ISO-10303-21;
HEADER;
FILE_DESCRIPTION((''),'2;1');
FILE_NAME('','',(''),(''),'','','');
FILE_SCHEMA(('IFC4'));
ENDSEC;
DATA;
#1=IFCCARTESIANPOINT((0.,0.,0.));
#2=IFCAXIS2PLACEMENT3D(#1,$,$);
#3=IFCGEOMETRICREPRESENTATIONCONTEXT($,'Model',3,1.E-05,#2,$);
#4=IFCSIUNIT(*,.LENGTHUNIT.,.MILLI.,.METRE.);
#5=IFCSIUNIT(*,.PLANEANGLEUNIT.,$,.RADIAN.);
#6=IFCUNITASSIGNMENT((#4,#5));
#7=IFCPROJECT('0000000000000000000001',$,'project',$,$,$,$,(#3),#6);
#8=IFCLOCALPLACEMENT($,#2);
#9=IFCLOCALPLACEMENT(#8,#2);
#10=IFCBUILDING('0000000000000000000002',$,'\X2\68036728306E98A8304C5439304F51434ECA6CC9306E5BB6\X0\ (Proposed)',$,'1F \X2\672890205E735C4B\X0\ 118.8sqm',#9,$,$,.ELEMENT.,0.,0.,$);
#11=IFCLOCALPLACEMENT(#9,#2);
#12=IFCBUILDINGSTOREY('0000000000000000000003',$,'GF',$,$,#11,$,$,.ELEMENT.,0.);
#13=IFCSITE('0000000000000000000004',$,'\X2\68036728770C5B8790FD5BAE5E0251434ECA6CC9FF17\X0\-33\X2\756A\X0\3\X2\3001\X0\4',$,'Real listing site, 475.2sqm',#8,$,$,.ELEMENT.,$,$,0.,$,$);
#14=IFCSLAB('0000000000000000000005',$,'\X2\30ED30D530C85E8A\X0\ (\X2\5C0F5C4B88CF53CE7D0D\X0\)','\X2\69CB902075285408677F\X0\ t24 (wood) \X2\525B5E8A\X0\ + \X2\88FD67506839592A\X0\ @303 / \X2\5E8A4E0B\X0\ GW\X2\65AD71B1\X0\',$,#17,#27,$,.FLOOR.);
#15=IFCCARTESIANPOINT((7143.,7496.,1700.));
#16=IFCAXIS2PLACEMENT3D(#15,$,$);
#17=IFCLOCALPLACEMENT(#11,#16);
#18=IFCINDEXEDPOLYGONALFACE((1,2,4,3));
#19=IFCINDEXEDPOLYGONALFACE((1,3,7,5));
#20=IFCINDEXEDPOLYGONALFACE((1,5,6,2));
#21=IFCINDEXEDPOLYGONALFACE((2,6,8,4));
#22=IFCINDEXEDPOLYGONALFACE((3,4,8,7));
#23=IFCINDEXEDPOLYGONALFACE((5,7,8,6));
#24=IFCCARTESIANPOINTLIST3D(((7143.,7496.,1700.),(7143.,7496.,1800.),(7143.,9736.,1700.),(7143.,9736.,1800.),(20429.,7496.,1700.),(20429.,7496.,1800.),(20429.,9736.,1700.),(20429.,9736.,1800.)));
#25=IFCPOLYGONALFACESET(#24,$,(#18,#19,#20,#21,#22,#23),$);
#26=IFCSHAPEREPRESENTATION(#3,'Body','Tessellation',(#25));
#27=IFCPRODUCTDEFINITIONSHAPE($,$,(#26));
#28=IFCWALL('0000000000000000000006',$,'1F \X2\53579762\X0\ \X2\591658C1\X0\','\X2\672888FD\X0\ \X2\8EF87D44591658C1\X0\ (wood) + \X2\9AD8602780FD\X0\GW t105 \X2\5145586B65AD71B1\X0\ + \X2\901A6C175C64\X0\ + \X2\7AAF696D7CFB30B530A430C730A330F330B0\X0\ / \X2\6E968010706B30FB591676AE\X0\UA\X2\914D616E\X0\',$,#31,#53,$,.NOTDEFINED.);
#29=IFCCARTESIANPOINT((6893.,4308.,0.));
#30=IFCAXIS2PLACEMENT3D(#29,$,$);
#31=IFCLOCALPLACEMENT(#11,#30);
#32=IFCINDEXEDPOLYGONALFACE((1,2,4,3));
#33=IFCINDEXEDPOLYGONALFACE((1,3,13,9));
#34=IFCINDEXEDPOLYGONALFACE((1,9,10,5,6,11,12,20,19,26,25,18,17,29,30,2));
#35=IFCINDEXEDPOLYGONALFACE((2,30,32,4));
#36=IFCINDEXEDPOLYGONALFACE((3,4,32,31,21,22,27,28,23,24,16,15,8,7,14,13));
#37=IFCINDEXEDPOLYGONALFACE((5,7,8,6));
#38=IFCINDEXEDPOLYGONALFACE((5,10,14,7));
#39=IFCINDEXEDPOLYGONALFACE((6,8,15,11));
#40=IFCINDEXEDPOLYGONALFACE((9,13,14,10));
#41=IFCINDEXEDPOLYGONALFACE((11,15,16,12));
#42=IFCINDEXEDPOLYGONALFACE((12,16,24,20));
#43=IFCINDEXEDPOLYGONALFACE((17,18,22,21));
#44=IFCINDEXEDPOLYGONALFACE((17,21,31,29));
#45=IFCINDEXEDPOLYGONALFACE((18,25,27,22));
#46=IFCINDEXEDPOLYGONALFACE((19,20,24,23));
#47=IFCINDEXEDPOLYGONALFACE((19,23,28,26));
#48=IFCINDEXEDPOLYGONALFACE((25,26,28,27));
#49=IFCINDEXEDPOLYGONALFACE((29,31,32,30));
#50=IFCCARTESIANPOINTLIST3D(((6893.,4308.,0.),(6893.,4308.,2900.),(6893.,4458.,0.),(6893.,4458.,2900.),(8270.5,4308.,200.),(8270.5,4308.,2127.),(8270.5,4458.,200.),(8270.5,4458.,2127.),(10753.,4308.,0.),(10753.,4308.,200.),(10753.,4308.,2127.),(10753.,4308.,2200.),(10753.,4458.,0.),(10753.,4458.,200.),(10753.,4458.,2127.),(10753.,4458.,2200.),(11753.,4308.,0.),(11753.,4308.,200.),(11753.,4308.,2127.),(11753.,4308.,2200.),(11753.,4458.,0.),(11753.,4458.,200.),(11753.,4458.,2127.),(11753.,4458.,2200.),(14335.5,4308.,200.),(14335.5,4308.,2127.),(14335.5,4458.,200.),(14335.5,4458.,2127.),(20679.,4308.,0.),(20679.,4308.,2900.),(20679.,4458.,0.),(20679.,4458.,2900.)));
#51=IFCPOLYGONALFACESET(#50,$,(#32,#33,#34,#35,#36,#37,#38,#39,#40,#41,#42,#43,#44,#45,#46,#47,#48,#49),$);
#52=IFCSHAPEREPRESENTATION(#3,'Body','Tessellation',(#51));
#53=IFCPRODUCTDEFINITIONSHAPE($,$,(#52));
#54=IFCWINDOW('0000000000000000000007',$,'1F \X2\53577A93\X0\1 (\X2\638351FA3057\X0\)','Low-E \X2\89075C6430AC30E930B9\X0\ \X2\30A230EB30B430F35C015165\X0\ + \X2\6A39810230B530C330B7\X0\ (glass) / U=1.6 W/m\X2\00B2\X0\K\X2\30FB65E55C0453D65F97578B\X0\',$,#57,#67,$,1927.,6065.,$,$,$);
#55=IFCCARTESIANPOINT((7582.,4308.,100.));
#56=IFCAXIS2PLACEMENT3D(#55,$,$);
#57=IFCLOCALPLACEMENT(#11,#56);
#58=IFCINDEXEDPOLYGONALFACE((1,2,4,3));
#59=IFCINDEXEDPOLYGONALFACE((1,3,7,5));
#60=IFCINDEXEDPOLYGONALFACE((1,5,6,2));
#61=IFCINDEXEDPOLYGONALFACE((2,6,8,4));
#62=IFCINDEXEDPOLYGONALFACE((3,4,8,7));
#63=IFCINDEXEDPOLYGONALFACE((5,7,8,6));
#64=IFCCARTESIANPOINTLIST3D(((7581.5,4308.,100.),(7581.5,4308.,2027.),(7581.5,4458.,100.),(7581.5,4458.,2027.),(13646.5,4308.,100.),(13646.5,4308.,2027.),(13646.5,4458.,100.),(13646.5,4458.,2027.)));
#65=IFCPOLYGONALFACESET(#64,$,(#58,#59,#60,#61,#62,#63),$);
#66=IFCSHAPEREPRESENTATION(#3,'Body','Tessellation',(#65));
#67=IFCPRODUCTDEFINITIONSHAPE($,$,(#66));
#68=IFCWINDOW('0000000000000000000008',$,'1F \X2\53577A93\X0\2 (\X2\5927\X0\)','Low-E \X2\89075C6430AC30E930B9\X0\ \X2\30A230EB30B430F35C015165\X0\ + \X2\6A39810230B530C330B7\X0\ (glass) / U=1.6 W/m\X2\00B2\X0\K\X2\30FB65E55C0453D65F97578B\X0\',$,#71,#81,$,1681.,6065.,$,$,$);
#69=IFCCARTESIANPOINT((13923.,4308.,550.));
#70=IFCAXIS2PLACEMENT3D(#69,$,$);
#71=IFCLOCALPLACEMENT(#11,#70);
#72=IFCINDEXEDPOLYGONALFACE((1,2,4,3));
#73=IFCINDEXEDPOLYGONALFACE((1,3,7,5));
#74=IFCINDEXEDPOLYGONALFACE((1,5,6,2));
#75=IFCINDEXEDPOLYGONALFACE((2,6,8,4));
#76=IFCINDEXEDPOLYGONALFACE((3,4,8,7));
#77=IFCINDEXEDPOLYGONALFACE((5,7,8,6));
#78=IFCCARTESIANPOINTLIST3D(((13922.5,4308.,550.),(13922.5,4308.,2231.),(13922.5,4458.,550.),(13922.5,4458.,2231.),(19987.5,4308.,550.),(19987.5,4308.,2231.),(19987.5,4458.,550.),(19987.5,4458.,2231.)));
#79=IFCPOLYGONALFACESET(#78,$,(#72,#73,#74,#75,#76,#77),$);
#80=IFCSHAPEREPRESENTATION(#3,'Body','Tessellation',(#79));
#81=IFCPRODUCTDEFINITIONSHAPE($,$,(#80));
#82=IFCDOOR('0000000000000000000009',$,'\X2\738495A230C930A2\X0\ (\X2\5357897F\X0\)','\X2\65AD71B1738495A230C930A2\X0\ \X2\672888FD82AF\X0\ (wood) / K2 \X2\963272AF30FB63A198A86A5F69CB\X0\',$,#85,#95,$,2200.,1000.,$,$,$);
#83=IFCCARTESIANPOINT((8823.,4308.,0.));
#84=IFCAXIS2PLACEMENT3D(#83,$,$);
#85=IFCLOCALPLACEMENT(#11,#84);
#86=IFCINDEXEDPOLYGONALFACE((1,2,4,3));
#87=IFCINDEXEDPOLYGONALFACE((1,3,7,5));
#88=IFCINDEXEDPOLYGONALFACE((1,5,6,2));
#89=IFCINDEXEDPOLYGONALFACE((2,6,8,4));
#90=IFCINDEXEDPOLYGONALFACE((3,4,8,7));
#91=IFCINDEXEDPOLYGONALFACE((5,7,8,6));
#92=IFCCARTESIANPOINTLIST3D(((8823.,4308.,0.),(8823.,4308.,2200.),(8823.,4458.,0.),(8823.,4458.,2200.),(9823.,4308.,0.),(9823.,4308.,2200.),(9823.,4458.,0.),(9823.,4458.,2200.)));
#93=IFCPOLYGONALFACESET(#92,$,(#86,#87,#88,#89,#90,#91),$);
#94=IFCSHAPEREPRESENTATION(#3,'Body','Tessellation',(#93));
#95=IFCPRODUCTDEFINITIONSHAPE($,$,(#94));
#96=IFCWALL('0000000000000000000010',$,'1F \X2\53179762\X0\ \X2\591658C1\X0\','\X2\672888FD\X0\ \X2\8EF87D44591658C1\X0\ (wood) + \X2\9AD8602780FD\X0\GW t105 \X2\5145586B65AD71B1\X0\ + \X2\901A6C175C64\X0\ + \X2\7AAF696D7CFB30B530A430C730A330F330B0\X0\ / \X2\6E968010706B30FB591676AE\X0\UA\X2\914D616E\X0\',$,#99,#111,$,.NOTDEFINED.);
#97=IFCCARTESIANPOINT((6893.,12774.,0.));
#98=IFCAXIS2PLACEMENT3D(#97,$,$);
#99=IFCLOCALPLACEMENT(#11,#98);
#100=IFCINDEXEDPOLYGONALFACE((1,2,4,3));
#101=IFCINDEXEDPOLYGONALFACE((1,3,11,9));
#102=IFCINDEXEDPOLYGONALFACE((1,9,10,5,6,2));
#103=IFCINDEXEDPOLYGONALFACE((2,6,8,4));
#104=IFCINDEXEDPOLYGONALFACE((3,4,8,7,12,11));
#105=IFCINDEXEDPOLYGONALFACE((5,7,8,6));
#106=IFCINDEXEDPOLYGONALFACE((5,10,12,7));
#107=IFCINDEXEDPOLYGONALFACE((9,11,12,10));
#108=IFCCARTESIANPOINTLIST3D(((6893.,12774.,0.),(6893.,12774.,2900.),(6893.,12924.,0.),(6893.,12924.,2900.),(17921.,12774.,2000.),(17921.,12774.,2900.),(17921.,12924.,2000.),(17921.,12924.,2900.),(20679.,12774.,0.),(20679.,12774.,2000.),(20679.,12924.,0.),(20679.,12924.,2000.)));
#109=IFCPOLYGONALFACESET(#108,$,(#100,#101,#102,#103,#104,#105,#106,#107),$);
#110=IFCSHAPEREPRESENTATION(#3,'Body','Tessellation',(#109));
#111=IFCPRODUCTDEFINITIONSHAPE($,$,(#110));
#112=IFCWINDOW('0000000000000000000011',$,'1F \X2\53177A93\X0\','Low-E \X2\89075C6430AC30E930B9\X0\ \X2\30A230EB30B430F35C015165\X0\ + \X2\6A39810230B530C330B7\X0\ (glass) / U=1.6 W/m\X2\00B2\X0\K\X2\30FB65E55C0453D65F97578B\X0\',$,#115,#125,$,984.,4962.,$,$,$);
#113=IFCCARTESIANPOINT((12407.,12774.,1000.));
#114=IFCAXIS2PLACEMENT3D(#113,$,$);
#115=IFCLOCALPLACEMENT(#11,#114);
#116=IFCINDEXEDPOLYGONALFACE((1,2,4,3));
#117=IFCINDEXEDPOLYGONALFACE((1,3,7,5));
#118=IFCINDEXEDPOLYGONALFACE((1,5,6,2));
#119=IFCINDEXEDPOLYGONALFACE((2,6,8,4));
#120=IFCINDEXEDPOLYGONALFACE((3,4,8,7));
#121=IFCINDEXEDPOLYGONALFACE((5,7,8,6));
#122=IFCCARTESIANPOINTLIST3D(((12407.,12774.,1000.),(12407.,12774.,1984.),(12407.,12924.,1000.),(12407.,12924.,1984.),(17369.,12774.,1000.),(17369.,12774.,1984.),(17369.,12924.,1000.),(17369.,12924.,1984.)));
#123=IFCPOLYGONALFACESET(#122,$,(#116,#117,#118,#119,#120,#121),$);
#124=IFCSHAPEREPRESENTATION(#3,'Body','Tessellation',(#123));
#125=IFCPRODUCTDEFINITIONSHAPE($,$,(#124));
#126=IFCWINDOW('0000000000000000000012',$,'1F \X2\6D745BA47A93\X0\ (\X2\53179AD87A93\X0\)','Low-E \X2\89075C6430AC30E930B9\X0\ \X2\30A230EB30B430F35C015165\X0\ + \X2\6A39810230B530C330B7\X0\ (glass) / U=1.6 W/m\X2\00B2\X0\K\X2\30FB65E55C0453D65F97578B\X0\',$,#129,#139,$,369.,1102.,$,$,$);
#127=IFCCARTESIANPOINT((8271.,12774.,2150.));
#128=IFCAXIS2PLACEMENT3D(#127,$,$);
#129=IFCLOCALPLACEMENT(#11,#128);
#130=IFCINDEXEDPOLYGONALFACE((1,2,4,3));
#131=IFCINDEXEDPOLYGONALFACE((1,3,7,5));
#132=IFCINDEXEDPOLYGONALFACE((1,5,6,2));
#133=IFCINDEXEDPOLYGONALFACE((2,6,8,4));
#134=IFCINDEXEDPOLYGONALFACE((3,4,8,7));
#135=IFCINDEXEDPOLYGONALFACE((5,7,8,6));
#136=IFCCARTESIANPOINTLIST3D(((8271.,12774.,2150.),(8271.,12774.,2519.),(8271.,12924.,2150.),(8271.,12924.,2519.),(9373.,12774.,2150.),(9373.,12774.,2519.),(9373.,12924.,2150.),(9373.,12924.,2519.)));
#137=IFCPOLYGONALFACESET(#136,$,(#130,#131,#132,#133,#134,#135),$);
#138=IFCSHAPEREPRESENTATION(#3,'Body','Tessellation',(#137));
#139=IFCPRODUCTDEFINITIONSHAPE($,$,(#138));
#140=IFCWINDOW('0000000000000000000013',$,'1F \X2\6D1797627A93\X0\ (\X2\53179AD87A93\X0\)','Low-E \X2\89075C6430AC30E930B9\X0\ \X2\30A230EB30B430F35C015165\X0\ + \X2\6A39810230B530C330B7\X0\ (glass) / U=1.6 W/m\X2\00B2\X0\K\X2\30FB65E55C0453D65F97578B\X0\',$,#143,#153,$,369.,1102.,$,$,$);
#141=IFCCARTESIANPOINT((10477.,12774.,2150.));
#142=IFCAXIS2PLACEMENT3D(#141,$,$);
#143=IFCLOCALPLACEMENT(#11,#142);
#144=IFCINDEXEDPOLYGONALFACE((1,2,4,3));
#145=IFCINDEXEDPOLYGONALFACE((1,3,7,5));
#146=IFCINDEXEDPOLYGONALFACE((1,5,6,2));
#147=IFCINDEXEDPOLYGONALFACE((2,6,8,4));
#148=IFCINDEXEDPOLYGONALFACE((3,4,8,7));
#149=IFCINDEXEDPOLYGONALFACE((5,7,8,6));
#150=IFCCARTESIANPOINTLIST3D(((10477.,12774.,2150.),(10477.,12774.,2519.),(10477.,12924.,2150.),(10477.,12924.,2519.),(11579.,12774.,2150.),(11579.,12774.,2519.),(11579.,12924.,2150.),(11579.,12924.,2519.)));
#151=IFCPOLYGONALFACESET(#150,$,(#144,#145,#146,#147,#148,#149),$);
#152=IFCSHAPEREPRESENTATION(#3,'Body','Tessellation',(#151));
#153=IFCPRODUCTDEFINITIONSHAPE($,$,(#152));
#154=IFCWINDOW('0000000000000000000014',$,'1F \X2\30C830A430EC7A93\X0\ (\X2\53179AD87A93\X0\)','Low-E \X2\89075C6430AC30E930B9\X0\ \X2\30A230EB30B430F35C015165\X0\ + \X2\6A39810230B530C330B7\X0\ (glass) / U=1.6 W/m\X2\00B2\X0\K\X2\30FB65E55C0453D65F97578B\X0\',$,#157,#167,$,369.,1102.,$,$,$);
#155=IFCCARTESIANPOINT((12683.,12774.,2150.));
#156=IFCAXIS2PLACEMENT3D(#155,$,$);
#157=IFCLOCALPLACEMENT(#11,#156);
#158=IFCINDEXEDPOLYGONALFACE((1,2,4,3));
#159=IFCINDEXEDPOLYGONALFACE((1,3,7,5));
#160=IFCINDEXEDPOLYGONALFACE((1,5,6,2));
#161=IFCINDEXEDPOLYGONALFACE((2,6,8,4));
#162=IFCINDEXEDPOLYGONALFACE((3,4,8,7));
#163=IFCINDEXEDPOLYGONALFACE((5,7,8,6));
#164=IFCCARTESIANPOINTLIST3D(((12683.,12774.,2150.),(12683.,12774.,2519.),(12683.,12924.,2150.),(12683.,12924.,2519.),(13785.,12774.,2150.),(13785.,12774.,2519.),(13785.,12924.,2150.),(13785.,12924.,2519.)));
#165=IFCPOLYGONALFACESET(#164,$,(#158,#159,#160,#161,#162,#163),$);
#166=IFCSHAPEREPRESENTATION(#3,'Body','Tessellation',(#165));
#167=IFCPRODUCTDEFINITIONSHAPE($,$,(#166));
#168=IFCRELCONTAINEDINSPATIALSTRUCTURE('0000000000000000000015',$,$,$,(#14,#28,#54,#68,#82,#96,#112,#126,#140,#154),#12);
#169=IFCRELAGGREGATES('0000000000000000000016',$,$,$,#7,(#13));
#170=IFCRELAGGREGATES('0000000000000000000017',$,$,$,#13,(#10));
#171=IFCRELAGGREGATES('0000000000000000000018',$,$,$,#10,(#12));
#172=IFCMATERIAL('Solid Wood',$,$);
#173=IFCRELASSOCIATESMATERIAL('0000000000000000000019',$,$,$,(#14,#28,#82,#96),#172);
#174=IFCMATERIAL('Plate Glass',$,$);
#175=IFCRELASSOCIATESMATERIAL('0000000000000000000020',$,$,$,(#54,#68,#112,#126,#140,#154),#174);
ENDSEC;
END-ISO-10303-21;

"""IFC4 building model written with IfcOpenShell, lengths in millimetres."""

from ifc_helpers import new_model, si_unit, frame, frame_2d, origin, place, context, project, spatial, rectangle, extrude, material, element, fill, save


model = new_model("IFC4")

# Units and contexts
model_context = context("Model", 3, precision=1e-05, world=origin())
ifc_project = project(units=[si_unit("LENGTHUNIT", "METRE", prefix="MILLI"), si_unit("PLANEANGLEUNIT", "RADIAN")], contexts=[model_context])

# Site, building, storey
site_placement = place(None, origin())
site = spatial("IfcSite", under=ifc_project, at=site_placement, Name="栃木県宇都宮市元今泉７-33番3、4", ObjectType="Real listing site, 475.2sqm", CompositionType="ELEMENT", RefElevation=0.0)
building_placement = place(site_placement, origin())
building = spatial("IfcBuilding", under=site, at=building_placement, Name="栃木の風が吹く元今泉の家 (Proposed)", ObjectType="1F 木造平屋 118.8sqm", CompositionType="ELEMENT", ElevationOfRefHeight=0.0, ElevationOfTerrain=0.0)
storey_placement = place(building_placement, origin())
storey = spatial("IfcBuildingStorey", under=building, at=storey_placement, Name="GF", CompositionType="ELEMENT", Elevation=0.0)

# Slab
ifc_material_1 = material(Name="Solid Wood")
slab_1_placement = place(storey_placement, frame((7143.0, 7496.0, 1700.0)))
element("IfcSlab", 1, at=slab_1_placement, inside=storey, material=ifc_material_1, Name="ロフト床 (小屋裏収納)", Description="構造用合板 t24 (wood) 剛床 + 製材根太 @303 / 床下 GW断熱", PredefinedType="FLOOR", context=model_context, shape_type="SweptSolid", body=[
    extrude(rectangle(XDim=13286.0, YDim=2240.0, at=frame_2d((6643.0, 1120.0))), frame((7143.0, 7496.0, 1700.0)), (0.0, 0.0, 1.0), 100.0),
])

# Wall, openings, windows, door
wall_1_placement = place(storey_placement, frame((6893.0, 4308.0, 0.0)))
wall_1 = element("IfcWall", 2, at=wall_1_placement, inside=storey, material=ifc_material_1, Name="1F 南面 外壁", Description="木製 軸組外壁 (wood) + 高性能GW t105 充填断熱 + 通気層 + 窯業系サイディング / 準耐火・外皮UA配慮", PredefinedType="NOTDEFINED", context=model_context, shape_type="SweptSolid", body=[
    extrude(rectangle(XDim=13786.0, YDim=150.0, at=frame_2d((6893.0, 75.0))), frame((6893.0, 4308.0, 0.0)), (0.0, 0.0, 1.0), 2900.0),
])
opening_1_placement = place(storey_placement, frame((7582.0, 4308.0, 100.0)))
opening_1 = element("IfcOpeningElement", 3, at=opening_1_placement, cuts=wall_1, PredefinedType="NOTDEFINED", context=model_context, shape_type="SweptSolid", body=[
    extrude(rectangle(XDim=6065.0, YDim=150.0, at=frame_2d((3032.0, 75.0))), frame((7582.0, 4308.0, 100.0)), (0.0, 0.0, 1.0), 1927.0),
])
opening_2_placement = place(storey_placement, frame((13923.0, 4308.0, 550.0)))
opening_2 = element("IfcOpeningElement", 4, at=opening_2_placement, cuts=wall_1, PredefinedType="NOTDEFINED", context=model_context, shape_type="SweptSolid", body=[
    extrude(rectangle(XDim=6065.0, YDim=150.0, at=frame_2d((3032.0, 75.0))), frame((13923.0, 4308.0, 550.0)), (0.0, 0.0, 1.0), 1681.0),
])
opening_3_placement = place(storey_placement, frame((8823.0, 4308.0, 0.0)))
opening_3 = element("IfcOpeningElement", 5, at=opening_3_placement, cuts=wall_1, PredefinedType="NOTDEFINED", context=model_context, shape_type="SweptSolid", body=[
    extrude(rectangle(XDim=1000.0, YDim=150.0, at=frame_2d((500.0, 75.0))), frame((8823.0, 4308.0, 0.0)), (0.0, 0.0, 1.0), 2200.0),
])
ifc_material_2 = material(Name="Plate Glass")
window_1_placement = place(storey_placement, frame((7582.0, 4308.0, 100.0)))
window_1 = element("IfcWindow", 6, at=window_1_placement, inside=storey, material=ifc_material_2, Name="1F 南窓1 (掃出し)", Description="Low-E 複層ガラス アルゴン封入 + 樹脂サッシ (glass) / U=1.6 W/m²K・日射取得型", OverallHeight=1927.0, OverallWidth=6065.0, context=model_context, shape_type="SweptSolid", body=[
    extrude(rectangle(XDim=6065.0, YDim=150.0, at=frame_2d((3032.0, 75.0))), frame((7582.0, 4308.0, 100.0)), (0.0, 0.0, 1.0), 1927.0),
])
fill(opening_1, window_1)
window_2_placement = place(storey_placement, frame((13923.0, 4308.0, 550.0)))
window_2 = element("IfcWindow", 7, at=window_2_placement, inside=storey, material=ifc_material_2, Name="1F 南窓2 (大)", Description="Low-E 複層ガラス アルゴン封入 + 樹脂サッシ (glass) / U=1.6 W/m²K・日射取得型", OverallHeight=1681.0, OverallWidth=6065.0, context=model_context, shape_type="SweptSolid", body=[
    extrude(rectangle(XDim=6065.0, YDim=150.0, at=frame_2d((3032.0, 75.0))), frame((13923.0, 4308.0, 550.0)), (0.0, 0.0, 1.0), 1681.0),
])
fill(opening_2, window_2)
door_1_placement = place(storey_placement, frame((8823.0, 4308.0, 0.0)))
door_1 = element("IfcDoor", 8, at=door_1_placement, inside=storey, material=ifc_material_1, Name="玄関ドア (南西)", Description="断熱玄関ドア 木製芯 (wood) / K2 防犯・採風機構", OverallHeight=2200.0, OverallWidth=1000.0, context=model_context, shape_type="SweptSolid", body=[
    extrude(rectangle(XDim=1000.0, YDim=150.0, at=frame_2d((500.0, 75.0))), frame((8823.0, 4308.0, 0.0)), (0.0, 0.0, 1.0), 2200.0),
])
fill(opening_3, door_1)

# Wall, openings, windows
wall_2_placement = place(storey_placement, frame((6893.0, 12774.0, 0.0)))
wall_2 = element("IfcWall", 9, at=wall_2_placement, inside=storey, material=ifc_material_1, Name="1F 北面 外壁", Description="木製 軸組外壁 (wood) + 高性能GW t105 充填断熱 + 通気層 + 窯業系サイディング / 準耐火・外皮UA配慮", PredefinedType="NOTDEFINED", context=model_context, shape_type="SweptSolid", body=[
    extrude(rectangle(XDim=13786.0, YDim=150.0, at=frame_2d((6893.0, 75.0))), frame((6893.0, 12774.0, 0.0)), (0.0, 0.0, 1.0), 2900.0),
])
opening_4_placement = place(storey_placement, frame((12407.0, 12774.0, 1000.0)))
opening_4 = element("IfcOpeningElement", 10, at=opening_4_placement, cuts=wall_2, PredefinedType="NOTDEFINED", context=model_context, shape_type="SweptSolid", body=[
    extrude(rectangle(XDim=4962.0, YDim=150.0, at=frame_2d((2481.0, 75.0))), frame((12407.0, 12774.0, 1000.0)), (0.0, 0.0, 1.0), 984.0),
])
opening_5_placement = place(storey_placement, frame((8271.0, 12774.0, 2150.0)))
opening_5 = element("IfcOpeningElement", 11, at=opening_5_placement, cuts=wall_2, PredefinedType="NOTDEFINED", context=model_context, shape_type="SweptSolid", body=[
    extrude(rectangle(XDim=1102.0, YDim=150.0, at=frame_2d((551.0, 75.0))), frame((8271.0, 12774.0, 2150.0)), (0.0, 0.0, 1.0), 369.0),
])
opening_6_placement = place(storey_placement, frame((10477.0, 12774.0, 2150.0)))
opening_6 = element("IfcOpeningElement", 12, at=opening_6_placement, cuts=wall_2, PredefinedType="NOTDEFINED", context=model_context, shape_type="SweptSolid", body=[
    extrude(rectangle(XDim=1102.0, YDim=150.0, at=frame_2d((551.0, 75.0))), frame((10477.0, 12774.0, 2150.0)), (0.0, 0.0, 1.0), 369.0),
])
opening_7_placement = place(storey_placement, frame((12683.0, 12774.0, 2150.0)))
opening_7 = element("IfcOpeningElement", 13, at=opening_7_placement, cuts=wall_2, PredefinedType="NOTDEFINED", context=model_context, shape_type="SweptSolid", body=[
    extrude(rectangle(XDim=1102.0, YDim=150.0, at=frame_2d((551.0, 75.0))), frame((12683.0, 12774.0, 2150.0)), (0.0, 0.0, 1.0), 369.0),
])
window_3_placement = place(storey_placement, frame((12407.0, 12774.0, 1000.0)))
window_3 = element("IfcWindow", 14, at=window_3_placement, inside=storey, material=ifc_material_2, Name="1F 北窓", Description="Low-E 複層ガラス アルゴン封入 + 樹脂サッシ (glass) / U=1.6 W/m²K・日射取得型", OverallHeight=984.0, OverallWidth=4962.0, context=model_context, shape_type="SweptSolid", body=[
    extrude(rectangle(XDim=4962.0, YDim=150.0, at=frame_2d((2481.0, 75.0))), frame((12407.0, 12774.0, 1000.0)), (0.0, 0.0, 1.0), 984.0),
])
fill(opening_4, window_3)
window_4_placement = place(storey_placement, frame((8271.0, 12774.0, 2150.0)))
window_4 = element("IfcWindow", 15, at=window_4_placement, inside=storey, material=ifc_material_2, Name="1F 浴室窓 (北高窓)", Description="Low-E 複層ガラス アルゴン封入 + 樹脂サッシ (glass) / U=1.6 W/m²K・日射取得型", OverallHeight=369.0, OverallWidth=1102.0, context=model_context, shape_type="SweptSolid", body=[
    extrude(rectangle(XDim=1102.0, YDim=150.0, at=frame_2d((551.0, 75.0))), frame((8271.0, 12774.0, 2150.0)), (0.0, 0.0, 1.0), 369.0),
])
fill(opening_5, window_4)
window_5_placement = place(storey_placement, frame((10477.0, 12774.0, 2150.0)))
window_5 = element("IfcWindow", 16, at=window_5_placement, inside=storey, material=ifc_material_2, Name="1F 洗面窓 (北高窓)", Description="Low-E 複層ガラス アルゴン封入 + 樹脂サッシ (glass) / U=1.6 W/m²K・日射取得型", OverallHeight=369.0, OverallWidth=1102.0, context=model_context, shape_type="SweptSolid", body=[
    extrude(rectangle(XDim=1102.0, YDim=150.0, at=frame_2d((551.0, 75.0))), frame((10477.0, 12774.0, 2150.0)), (0.0, 0.0, 1.0), 369.0),
])
fill(opening_6, window_5)
window_6_placement = place(storey_placement, frame((12683.0, 12774.0, 2150.0)))
window_6 = element("IfcWindow", 17, at=window_6_placement, inside=storey, material=ifc_material_2, Name="1F トイレ窓 (北高窓)", Description="Low-E 複層ガラス アルゴン封入 + 樹脂サッシ (glass) / U=1.6 W/m²K・日射取得型", OverallHeight=369.0, OverallWidth=1102.0, context=model_context, shape_type="SweptSolid", body=[
    extrude(rectangle(XDim=1102.0, YDim=150.0, at=frame_2d((551.0, 75.0))), frame((12683.0, 12774.0, 2150.0)), (0.0, 0.0, 1.0), 369.0),
])
fill(opening_7, window_6)

save(model, "model.ifc")
